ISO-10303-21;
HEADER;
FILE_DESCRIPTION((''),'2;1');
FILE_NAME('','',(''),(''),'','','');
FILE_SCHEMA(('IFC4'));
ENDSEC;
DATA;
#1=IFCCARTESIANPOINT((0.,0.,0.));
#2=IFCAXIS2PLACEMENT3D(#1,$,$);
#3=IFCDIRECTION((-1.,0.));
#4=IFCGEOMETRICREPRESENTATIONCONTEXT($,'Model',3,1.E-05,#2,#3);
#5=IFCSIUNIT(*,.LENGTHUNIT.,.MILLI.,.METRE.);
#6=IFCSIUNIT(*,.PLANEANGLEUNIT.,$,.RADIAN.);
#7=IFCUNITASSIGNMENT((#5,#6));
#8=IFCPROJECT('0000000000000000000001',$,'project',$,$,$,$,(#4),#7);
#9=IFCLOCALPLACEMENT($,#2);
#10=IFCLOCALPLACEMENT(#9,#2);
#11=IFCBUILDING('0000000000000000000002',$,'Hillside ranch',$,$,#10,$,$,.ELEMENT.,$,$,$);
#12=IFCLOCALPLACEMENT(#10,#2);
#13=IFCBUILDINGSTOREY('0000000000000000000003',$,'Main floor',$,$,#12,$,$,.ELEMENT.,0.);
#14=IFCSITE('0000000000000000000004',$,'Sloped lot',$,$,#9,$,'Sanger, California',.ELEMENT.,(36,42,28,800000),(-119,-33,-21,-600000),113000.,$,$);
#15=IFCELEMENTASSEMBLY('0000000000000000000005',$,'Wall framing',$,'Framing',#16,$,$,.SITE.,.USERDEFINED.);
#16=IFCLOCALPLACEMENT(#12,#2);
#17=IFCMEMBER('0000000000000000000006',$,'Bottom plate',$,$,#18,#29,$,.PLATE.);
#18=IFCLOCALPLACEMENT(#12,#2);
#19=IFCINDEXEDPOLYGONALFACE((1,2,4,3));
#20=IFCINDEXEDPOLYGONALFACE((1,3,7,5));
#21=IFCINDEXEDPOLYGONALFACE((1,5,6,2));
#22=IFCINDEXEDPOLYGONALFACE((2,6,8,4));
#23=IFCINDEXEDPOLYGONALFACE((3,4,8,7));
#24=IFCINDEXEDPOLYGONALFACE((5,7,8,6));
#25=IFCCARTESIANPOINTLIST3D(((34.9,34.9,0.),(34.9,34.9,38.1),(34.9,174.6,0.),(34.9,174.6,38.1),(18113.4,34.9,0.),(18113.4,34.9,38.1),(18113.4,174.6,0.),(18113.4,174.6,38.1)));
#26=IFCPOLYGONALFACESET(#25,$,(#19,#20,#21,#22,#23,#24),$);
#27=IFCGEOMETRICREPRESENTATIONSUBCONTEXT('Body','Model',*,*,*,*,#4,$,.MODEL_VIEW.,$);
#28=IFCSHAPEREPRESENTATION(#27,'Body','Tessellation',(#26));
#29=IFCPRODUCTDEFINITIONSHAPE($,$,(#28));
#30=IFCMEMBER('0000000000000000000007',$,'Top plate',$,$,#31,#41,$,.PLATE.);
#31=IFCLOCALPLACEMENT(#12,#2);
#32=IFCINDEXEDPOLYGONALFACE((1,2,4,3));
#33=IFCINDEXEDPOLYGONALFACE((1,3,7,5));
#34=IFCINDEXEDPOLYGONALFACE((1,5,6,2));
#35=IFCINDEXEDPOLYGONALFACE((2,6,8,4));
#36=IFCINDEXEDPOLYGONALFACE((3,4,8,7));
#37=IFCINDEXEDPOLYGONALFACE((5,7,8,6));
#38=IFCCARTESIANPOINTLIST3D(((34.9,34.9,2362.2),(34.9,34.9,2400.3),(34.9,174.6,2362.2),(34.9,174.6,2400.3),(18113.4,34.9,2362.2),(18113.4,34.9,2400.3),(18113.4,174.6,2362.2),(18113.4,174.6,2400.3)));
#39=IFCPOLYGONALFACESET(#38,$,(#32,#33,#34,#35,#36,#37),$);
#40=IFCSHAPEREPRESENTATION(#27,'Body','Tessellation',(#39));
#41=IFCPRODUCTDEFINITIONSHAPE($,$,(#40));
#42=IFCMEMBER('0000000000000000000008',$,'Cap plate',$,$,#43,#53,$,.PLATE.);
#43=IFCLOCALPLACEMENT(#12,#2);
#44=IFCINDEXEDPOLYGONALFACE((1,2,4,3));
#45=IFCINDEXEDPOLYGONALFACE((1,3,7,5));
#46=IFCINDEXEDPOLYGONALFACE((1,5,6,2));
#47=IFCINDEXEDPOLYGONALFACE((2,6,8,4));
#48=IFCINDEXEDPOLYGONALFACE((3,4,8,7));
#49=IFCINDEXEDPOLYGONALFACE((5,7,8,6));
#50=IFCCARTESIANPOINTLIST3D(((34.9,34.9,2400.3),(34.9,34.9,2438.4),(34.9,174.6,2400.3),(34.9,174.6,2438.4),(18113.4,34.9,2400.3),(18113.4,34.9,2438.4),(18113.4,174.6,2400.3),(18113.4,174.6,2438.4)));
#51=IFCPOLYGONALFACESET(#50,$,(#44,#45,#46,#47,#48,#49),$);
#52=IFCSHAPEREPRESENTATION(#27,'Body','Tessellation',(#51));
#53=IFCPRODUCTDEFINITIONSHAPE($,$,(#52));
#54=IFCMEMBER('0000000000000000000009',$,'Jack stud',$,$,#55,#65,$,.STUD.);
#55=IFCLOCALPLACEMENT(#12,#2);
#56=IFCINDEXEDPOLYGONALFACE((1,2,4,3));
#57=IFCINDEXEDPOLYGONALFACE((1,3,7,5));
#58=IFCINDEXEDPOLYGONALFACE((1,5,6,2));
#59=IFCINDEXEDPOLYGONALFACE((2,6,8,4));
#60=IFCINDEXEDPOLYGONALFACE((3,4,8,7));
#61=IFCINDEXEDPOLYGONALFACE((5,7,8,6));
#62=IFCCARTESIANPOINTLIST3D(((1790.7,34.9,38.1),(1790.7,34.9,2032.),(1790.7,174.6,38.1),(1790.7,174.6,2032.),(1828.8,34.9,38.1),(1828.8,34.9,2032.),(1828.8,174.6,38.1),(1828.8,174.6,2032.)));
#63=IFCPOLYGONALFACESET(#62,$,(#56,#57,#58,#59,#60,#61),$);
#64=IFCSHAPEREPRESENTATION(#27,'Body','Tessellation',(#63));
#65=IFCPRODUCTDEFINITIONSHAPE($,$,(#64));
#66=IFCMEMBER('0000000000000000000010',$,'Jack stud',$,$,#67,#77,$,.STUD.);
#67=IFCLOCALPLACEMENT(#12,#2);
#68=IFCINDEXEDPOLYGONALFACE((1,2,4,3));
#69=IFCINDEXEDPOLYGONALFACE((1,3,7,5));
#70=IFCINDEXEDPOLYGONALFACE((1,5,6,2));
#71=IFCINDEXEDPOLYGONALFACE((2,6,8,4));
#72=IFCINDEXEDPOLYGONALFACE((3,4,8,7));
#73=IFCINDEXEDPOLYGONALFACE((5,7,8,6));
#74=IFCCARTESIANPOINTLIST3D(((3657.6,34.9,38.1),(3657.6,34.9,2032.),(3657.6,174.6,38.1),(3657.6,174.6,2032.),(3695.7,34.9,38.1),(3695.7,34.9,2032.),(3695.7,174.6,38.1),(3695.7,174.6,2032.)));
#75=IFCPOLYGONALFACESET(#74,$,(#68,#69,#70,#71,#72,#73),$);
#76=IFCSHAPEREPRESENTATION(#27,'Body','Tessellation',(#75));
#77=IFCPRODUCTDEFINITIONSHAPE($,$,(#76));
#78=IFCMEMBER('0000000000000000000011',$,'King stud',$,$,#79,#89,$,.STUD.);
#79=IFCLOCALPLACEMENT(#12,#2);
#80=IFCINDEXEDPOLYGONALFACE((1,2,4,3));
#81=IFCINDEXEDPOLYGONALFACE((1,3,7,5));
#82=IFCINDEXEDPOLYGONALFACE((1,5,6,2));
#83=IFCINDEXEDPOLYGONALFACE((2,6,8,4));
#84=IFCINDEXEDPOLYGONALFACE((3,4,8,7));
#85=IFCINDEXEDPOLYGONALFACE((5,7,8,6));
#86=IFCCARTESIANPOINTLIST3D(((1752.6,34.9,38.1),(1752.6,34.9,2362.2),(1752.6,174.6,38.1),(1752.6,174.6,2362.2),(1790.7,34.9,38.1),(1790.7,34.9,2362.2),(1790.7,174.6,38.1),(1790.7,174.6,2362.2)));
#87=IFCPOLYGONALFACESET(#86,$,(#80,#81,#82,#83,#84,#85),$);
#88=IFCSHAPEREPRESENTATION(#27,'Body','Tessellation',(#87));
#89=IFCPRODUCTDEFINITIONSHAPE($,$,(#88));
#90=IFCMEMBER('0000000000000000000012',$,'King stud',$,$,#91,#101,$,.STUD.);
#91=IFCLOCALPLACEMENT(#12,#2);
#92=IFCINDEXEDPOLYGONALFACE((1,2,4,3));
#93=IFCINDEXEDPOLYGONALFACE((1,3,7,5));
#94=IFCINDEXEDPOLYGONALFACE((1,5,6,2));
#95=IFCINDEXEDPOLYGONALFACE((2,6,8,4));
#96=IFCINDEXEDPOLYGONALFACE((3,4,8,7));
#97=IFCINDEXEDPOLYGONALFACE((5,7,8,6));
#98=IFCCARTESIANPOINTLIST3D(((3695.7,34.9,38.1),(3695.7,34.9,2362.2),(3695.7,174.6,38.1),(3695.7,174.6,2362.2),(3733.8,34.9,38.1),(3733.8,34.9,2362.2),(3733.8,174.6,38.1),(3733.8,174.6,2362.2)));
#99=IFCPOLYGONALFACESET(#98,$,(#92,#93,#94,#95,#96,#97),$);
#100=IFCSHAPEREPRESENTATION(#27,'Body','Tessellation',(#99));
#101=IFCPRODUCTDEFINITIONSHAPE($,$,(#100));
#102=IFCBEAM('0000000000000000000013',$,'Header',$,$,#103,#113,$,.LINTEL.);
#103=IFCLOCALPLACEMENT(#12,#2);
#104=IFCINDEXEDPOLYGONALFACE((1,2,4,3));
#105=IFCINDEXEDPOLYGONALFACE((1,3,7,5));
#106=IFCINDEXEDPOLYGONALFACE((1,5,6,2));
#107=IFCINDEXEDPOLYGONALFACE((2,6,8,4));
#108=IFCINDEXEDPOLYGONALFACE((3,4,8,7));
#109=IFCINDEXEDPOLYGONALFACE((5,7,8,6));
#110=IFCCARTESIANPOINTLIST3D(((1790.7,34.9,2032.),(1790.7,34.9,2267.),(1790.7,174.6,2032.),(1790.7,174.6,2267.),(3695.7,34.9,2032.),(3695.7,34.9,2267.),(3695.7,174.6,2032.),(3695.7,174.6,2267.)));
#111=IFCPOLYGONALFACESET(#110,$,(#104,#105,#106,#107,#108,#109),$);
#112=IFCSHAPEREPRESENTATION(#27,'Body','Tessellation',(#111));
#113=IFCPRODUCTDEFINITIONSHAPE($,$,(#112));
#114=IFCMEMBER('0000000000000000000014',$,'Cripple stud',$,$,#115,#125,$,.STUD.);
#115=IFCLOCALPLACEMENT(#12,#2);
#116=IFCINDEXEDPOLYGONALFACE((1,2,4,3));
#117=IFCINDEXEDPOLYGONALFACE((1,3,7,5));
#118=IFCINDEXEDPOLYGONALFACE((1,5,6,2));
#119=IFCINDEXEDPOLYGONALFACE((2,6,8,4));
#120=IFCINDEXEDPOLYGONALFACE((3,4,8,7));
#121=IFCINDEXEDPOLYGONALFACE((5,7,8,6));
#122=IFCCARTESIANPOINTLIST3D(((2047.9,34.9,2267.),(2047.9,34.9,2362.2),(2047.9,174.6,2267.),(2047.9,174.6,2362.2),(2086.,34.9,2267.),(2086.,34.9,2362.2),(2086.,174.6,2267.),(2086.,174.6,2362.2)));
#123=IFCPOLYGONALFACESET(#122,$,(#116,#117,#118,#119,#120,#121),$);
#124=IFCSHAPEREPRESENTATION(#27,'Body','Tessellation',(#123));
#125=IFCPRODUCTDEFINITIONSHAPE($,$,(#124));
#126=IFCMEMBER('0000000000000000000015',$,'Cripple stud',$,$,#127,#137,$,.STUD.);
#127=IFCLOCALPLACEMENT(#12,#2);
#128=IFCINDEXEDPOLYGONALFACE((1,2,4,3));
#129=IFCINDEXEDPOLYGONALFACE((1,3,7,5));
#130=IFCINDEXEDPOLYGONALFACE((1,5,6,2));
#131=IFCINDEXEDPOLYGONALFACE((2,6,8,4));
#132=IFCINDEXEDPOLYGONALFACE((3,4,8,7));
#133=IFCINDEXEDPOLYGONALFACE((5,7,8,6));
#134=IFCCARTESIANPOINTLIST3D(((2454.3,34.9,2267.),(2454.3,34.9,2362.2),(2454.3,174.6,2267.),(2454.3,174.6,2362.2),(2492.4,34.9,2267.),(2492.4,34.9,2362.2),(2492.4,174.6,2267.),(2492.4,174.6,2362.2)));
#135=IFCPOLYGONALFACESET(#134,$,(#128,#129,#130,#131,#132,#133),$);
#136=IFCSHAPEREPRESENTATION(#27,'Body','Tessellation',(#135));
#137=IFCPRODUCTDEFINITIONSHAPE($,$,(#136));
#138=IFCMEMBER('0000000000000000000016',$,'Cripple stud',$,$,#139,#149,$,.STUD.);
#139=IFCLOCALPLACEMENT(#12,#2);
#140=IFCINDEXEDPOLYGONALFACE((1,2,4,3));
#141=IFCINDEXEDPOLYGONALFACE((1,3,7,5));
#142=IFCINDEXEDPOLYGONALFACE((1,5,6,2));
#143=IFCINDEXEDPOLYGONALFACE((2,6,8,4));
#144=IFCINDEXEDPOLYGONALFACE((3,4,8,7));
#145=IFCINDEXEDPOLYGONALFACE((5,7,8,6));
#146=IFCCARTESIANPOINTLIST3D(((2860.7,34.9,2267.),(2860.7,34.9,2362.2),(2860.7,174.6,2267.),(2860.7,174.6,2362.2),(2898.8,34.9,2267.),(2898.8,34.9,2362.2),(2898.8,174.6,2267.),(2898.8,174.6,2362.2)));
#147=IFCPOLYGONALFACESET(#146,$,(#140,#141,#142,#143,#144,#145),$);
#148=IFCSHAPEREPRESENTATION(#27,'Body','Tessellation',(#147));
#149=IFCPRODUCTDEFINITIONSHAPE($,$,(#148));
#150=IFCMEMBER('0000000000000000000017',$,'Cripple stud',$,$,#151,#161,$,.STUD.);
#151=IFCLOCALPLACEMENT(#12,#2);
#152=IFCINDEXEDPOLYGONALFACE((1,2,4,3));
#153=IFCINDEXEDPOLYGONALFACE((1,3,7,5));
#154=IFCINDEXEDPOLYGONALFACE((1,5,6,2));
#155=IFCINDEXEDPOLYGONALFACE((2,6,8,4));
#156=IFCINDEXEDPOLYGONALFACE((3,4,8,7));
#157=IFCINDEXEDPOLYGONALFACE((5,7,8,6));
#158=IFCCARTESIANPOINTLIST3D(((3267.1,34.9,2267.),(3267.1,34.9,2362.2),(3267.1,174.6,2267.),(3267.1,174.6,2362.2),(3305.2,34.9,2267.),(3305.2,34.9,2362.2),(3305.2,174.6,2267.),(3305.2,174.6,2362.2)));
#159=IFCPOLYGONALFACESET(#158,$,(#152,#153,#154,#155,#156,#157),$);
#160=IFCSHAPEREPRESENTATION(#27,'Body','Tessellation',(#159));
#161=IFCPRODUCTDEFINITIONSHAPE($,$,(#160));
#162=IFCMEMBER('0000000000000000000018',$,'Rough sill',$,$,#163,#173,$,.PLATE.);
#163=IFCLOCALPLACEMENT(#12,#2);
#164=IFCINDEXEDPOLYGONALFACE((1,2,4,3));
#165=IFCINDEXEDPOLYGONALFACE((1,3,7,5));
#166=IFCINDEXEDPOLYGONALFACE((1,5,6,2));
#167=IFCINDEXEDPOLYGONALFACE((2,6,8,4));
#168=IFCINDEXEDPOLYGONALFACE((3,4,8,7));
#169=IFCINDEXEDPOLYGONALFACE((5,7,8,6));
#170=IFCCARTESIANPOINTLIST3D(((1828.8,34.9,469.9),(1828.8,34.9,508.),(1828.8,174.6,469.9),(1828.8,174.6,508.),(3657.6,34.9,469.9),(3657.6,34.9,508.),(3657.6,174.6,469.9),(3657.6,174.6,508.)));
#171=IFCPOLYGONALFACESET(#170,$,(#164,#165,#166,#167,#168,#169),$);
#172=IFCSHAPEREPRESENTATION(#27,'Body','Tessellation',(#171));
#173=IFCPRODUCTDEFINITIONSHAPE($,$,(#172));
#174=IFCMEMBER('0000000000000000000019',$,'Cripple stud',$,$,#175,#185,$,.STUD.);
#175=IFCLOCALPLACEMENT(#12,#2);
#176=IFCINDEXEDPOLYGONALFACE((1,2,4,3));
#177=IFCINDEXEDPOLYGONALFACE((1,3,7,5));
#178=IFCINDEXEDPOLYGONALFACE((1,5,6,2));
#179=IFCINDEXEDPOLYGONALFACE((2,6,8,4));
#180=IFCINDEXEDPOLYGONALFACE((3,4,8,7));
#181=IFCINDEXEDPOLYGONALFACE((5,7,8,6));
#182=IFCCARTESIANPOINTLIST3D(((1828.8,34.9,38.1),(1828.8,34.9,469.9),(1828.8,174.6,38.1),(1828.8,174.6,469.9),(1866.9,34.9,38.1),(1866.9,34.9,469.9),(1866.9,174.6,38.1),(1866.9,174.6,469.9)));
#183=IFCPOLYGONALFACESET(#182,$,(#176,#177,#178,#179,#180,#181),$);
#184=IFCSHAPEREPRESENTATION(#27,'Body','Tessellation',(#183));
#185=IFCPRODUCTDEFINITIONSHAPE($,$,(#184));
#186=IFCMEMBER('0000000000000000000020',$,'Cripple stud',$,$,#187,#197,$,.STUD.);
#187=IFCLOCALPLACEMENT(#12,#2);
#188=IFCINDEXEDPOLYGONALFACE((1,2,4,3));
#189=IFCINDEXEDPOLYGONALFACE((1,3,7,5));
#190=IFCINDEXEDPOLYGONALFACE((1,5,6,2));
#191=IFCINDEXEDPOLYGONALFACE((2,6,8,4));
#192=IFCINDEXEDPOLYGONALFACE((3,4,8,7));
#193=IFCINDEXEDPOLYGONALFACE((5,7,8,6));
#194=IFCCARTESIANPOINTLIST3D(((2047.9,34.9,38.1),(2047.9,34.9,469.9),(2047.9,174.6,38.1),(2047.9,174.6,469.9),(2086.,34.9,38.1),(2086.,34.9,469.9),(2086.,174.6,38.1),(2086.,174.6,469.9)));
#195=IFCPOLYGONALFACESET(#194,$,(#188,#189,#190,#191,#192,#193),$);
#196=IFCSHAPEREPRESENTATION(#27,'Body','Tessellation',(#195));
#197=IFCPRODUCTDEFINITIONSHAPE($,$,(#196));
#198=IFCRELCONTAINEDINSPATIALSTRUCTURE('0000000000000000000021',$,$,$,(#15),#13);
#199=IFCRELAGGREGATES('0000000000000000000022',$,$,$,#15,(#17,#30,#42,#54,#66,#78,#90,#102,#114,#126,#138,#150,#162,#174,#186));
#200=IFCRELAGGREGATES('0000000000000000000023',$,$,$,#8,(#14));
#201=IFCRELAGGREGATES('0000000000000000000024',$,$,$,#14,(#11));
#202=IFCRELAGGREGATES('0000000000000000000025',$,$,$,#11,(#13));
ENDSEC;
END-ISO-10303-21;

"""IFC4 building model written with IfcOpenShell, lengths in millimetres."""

from ifc_helpers import new_model, si_unit, direction, frame, origin, origin_with_axes, place, context, subcontext, project, spatial, polyline, outline, extrude, element, aggregate, save


model = new_model("IFC4")

# Units and contexts
model_context = context("Model", 3, precision=1e-05, world=origin(), true_north=direction((-1.0, 0.0)))
body_context = subcontext(model_context, "Body", "Model", "MODEL_VIEW")
ifc_project = project(units=[si_unit("LENGTHUNIT", "METRE", prefix="MILLI"), si_unit("PLANEANGLEUNIT", "RADIAN")], contexts=[model_context])

# Site, building, storey
site_placement = place(None, origin())
site = spatial("IfcSite", under=ifc_project, at=site_placement, Name="Sloped lot", LongName="Sanger, California", CompositionType="ELEMENT", RefLatitude=(36, 42, 28, 800000), RefLongitude=(-119, -33, -21, -600000), RefElevation=113000.0)
building_placement = place(site_placement, origin())
building = spatial("IfcBuilding", under=site, at=building_placement, Name="Hillside ranch", CompositionType="ELEMENT")
storey_placement = place(building_placement, origin())
storey = spatial("IfcBuildingStorey", under=building, at=storey_placement, Name="Main floor", CompositionType="ELEMENT", Elevation=0.0)

# Element assembly, members, beam
assembly_1_placement = place(storey_placement, origin_with_axes())
assembly_1 = element("IfcElementAssembly", 1, at=assembly_1_placement, inside=storey, Name="Wall framing", ObjectType="Framing", AssemblyPlace="SITE", PredefinedType="USERDEFINED")
member_1_placement = place(storey_placement, origin_with_axes())
member_1 = element("IfcMember", 2, at=member_1_placement, Name="Bottom plate", PredefinedType="PLATE", context=body_context, shape_type="SweptSolid", body=[
    extrude(outline(polyline([(0.0, 0.0), (18078.5, 0.0), (18078.5, 139.7), (0.0, 139.7), (0.0, 0.0)])), frame((34.9, 34.9, 0.0), z_axis=(0.0, 0.0, 1.0), x_axis=(1.0, 0.0, 0.0)), (0.0, 0.0, 1.0), 38.1),
])
member_2_placement = place(storey_placement, origin_with_axes())
member_2 = element("IfcMember", 3, at=member_2_placement, Name="Top plate", PredefinedType="PLATE", context=body_context, shape_type="SweptSolid", body=[
    extrude(outline(polyline([(0.0, 0.0), (18078.5, 0.0), (18078.5, 139.7), (0.0, 139.7), (0.0, 0.0)])), frame((34.9, 34.9, 2362.2), z_axis=(0.0, 0.0, 1.0), x_axis=(1.0, 0.0, 0.0)), (0.0, 0.0, 1.0), 38.1),
])
member_3_placement = place(storey_placement, origin_with_axes())
member_3 = element("IfcMember", 4, at=member_3_placement, Name="Cap plate", PredefinedType="PLATE", context=body_context, shape_type="SweptSolid", body=[
    extrude(outline(polyline([(0.0, 0.0), (18078.5, 0.0), (18078.5, 139.7), (0.0, 139.7), (0.0, 0.0)])), frame((34.9, 34.9, 2400.3), z_axis=(0.0, 0.0, 1.0), x_axis=(1.0, 0.0, 0.0)), (0.0, 0.0, 1.0), 38.1),
])
member_4_placement = place(storey_placement, origin_with_axes())
member_4 = element("IfcMember", 5, at=member_4_placement, Name="Jack stud", PredefinedType="STUD", context=body_context, shape_type="SweptSolid", body=[
    extrude(outline(polyline([(0.0, 0.0), (38.1, 0.0), (38.1, 139.7), (0.0, 139.7), (0.0, 0.0)])), frame((1790.7, 34.9, 38.1), z_axis=(0.0, 0.0, 1.0), x_axis=(1.0, 0.0, 0.0)), (0.0, 0.0, 1.0), 1993.9),
])
member_5_placement = place(storey_placement, origin_with_axes())
member_5 = element("IfcMember", 6, at=member_5_placement, Name="Jack stud", PredefinedType="STUD", context=body_context, shape_type="SweptSolid", body=[
    extrude(outline(polyline([(0.0, 0.0), (38.1, 0.0), (38.1, 139.7), (0.0, 139.7), (0.0, 0.0)])), frame((3657.6, 34.9, 38.1), z_axis=(0.0, 0.0, 1.0), x_axis=(1.0, 0.0, 0.0)), (0.0, 0.0, 1.0), 1993.9),
])
member_6_placement = place(storey_placement, origin_with_axes())
member_6 = element("IfcMember", 7, at=member_6_placement, Name="King stud", PredefinedType="STUD", context=body_context, shape_type="SweptSolid", body=[
    extrude(outline(polyline([(0.0, 0.0), (38.1, 0.0), (38.1, 139.7), (0.0, 139.7), (0.0, 0.0)])), frame((1752.6, 34.9, 38.1), z_axis=(0.0, 0.0, 1.0), x_axis=(1.0, 0.0, 0.0)), (0.0, 0.0, 1.0), 2324.1),
])
member_7_placement = place(storey_placement, origin_with_axes())
member_7 = element("IfcMember", 8, at=member_7_placement, Name="King stud", PredefinedType="STUD", context=body_context, shape_type="SweptSolid", body=[
    extrude(outline(polyline([(0.0, 0.0), (38.1, 0.0), (38.1, 139.7), (0.0, 139.7), (0.0, 0.0)])), frame((3695.7, 34.9, 38.1), z_axis=(0.0, 0.0, 1.0), x_axis=(1.0, 0.0, 0.0)), (0.0, 0.0, 1.0), 2324.1),
])
beam_placement = place(storey_placement, origin_with_axes())
beam = element("IfcBeam", 9, at=beam_placement, Name="Header", PredefinedType="LINTEL", context=body_context, shape_type="SweptSolid", body=[
    extrude(outline(polyline([(0.0, 0.0), (1905.0, 0.0), (1905.0, 139.7), (0.0, 139.7), (0.0, 0.0)])), frame((1790.7, 34.9, 2032.0), z_axis=(0.0, 0.0, 1.0), x_axis=(1.0, 0.0, 0.0)), (0.0, 0.0, 1.0), 234.9),
])
member_8_placement = place(storey_placement, origin_with_axes())
member_8 = element("IfcMember", 10, at=member_8_placement, Name="Cripple stud", PredefinedType="STUD", context=body_context, shape_type="SweptSolid", body=[
    extrude(outline(polyline([(0.0, 0.0), (38.1, 0.0), (38.1, 139.7), (0.0, 139.7), (0.0, 0.0)])), frame((2047.9, 34.9, 2266.9), z_axis=(0.0, 0.0, 1.0), x_axis=(1.0, 0.0, 0.0)), (0.0, 0.0, 1.0), 95.2),
])
member_9_placement = place(storey_placement, origin_with_axes())
member_9 = element("IfcMember", 11, at=member_9_placement, Name="Cripple stud", PredefinedType="STUD", context=body_context, shape_type="SweptSolid", body=[
    extrude(outline(polyline([(0.0, 0.0), (38.1, 0.0), (38.1, 139.7), (0.0, 139.7), (0.0, 0.0)])), frame((2454.3, 34.9, 2266.9), z_axis=(0.0, 0.0, 1.0), x_axis=(1.0, 0.0, 0.0)), (0.0, 0.0, 1.0), 95.2),
])
member_10_placement = place(storey_placement, origin_with_axes())
member_10 = element("IfcMember", 12, at=member_10_placement, Name="Cripple stud", PredefinedType="STUD", context=body_context, shape_type="SweptSolid", body=[
    extrude(outline(polyline([(0.0, 0.0), (38.1, 0.0), (38.1, 139.7), (0.0, 139.7), (0.0, 0.0)])), frame((2860.7, 34.9, 2266.9), z_axis=(0.0, 0.0, 1.0), x_axis=(1.0, 0.0, 0.0)), (0.0, 0.0, 1.0), 95.2),
])
member_11_placement = place(storey_placement, origin_with_axes())
member_11 = element("IfcMember", 13, at=member_11_placement, Name="Cripple stud", PredefinedType="STUD", context=body_context, shape_type="SweptSolid", body=[
    extrude(outline(polyline([(0.0, 0.0), (38.1, 0.0), (38.1, 139.7), (0.0, 139.7), (0.0, 0.0)])), frame((3267.1, 34.9, 2266.9), z_axis=(0.0, 0.0, 1.0), x_axis=(1.0, 0.0, 0.0)), (0.0, 0.0, 1.0), 95.2),
])
member_12_placement = place(storey_placement, origin_with_axes())
member_12 = element("IfcMember", 14, at=member_12_placement, Name="Rough sill", PredefinedType="PLATE", context=body_context, shape_type="SweptSolid", body=[
    extrude(outline(polyline([(0.0, 0.0), (1828.8, 0.0), (1828.8, 139.7), (0.0, 139.7), (0.0, 0.0)])), frame((1828.8, 34.9, 469.9), z_axis=(0.0, 0.0, 1.0), x_axis=(1.0, 0.0, 0.0)), (0.0, 0.0, 1.0), 38.1),
])
member_13_placement = place(storey_placement, origin_with_axes())
member_13 = element("IfcMember", 15, at=member_13_placement, Name="Cripple stud", PredefinedType="STUD", context=body_context, shape_type="SweptSolid", body=[
    extrude(outline(polyline([(0.0, 0.0), (38.1, 0.0), (38.1, 139.7), (0.0, 139.7), (0.0, 0.0)])), frame((1828.8, 34.9, 38.1), z_axis=(0.0, 0.0, 1.0), x_axis=(1.0, 0.0, 0.0)), (0.0, 0.0, 1.0), 431.8),
])
member_14_placement = place(storey_placement, origin_with_axes())
member_14 = element("IfcMember", 16, at=member_14_placement, Name="Cripple stud", PredefinedType="STUD", context=body_context, shape_type="SweptSolid", body=[
    extrude(outline(polyline([(0.0, 0.0), (38.1, 0.0), (38.1, 139.7), (0.0, 139.7), (0.0, 0.0)])), frame((2047.9, 34.9, 38.1), z_axis=(0.0, 0.0, 1.0), x_axis=(1.0, 0.0, 0.0)), (0.0, 0.0, 1.0), 431.8),
])
aggregate(assembly_1, [member_1, member_2, member_3, member_4, member_5, member_6, member_7, beam, member_8, member_9, member_10, member_11, member_12, member_13, member_14])

save(model, "model.ifc")
